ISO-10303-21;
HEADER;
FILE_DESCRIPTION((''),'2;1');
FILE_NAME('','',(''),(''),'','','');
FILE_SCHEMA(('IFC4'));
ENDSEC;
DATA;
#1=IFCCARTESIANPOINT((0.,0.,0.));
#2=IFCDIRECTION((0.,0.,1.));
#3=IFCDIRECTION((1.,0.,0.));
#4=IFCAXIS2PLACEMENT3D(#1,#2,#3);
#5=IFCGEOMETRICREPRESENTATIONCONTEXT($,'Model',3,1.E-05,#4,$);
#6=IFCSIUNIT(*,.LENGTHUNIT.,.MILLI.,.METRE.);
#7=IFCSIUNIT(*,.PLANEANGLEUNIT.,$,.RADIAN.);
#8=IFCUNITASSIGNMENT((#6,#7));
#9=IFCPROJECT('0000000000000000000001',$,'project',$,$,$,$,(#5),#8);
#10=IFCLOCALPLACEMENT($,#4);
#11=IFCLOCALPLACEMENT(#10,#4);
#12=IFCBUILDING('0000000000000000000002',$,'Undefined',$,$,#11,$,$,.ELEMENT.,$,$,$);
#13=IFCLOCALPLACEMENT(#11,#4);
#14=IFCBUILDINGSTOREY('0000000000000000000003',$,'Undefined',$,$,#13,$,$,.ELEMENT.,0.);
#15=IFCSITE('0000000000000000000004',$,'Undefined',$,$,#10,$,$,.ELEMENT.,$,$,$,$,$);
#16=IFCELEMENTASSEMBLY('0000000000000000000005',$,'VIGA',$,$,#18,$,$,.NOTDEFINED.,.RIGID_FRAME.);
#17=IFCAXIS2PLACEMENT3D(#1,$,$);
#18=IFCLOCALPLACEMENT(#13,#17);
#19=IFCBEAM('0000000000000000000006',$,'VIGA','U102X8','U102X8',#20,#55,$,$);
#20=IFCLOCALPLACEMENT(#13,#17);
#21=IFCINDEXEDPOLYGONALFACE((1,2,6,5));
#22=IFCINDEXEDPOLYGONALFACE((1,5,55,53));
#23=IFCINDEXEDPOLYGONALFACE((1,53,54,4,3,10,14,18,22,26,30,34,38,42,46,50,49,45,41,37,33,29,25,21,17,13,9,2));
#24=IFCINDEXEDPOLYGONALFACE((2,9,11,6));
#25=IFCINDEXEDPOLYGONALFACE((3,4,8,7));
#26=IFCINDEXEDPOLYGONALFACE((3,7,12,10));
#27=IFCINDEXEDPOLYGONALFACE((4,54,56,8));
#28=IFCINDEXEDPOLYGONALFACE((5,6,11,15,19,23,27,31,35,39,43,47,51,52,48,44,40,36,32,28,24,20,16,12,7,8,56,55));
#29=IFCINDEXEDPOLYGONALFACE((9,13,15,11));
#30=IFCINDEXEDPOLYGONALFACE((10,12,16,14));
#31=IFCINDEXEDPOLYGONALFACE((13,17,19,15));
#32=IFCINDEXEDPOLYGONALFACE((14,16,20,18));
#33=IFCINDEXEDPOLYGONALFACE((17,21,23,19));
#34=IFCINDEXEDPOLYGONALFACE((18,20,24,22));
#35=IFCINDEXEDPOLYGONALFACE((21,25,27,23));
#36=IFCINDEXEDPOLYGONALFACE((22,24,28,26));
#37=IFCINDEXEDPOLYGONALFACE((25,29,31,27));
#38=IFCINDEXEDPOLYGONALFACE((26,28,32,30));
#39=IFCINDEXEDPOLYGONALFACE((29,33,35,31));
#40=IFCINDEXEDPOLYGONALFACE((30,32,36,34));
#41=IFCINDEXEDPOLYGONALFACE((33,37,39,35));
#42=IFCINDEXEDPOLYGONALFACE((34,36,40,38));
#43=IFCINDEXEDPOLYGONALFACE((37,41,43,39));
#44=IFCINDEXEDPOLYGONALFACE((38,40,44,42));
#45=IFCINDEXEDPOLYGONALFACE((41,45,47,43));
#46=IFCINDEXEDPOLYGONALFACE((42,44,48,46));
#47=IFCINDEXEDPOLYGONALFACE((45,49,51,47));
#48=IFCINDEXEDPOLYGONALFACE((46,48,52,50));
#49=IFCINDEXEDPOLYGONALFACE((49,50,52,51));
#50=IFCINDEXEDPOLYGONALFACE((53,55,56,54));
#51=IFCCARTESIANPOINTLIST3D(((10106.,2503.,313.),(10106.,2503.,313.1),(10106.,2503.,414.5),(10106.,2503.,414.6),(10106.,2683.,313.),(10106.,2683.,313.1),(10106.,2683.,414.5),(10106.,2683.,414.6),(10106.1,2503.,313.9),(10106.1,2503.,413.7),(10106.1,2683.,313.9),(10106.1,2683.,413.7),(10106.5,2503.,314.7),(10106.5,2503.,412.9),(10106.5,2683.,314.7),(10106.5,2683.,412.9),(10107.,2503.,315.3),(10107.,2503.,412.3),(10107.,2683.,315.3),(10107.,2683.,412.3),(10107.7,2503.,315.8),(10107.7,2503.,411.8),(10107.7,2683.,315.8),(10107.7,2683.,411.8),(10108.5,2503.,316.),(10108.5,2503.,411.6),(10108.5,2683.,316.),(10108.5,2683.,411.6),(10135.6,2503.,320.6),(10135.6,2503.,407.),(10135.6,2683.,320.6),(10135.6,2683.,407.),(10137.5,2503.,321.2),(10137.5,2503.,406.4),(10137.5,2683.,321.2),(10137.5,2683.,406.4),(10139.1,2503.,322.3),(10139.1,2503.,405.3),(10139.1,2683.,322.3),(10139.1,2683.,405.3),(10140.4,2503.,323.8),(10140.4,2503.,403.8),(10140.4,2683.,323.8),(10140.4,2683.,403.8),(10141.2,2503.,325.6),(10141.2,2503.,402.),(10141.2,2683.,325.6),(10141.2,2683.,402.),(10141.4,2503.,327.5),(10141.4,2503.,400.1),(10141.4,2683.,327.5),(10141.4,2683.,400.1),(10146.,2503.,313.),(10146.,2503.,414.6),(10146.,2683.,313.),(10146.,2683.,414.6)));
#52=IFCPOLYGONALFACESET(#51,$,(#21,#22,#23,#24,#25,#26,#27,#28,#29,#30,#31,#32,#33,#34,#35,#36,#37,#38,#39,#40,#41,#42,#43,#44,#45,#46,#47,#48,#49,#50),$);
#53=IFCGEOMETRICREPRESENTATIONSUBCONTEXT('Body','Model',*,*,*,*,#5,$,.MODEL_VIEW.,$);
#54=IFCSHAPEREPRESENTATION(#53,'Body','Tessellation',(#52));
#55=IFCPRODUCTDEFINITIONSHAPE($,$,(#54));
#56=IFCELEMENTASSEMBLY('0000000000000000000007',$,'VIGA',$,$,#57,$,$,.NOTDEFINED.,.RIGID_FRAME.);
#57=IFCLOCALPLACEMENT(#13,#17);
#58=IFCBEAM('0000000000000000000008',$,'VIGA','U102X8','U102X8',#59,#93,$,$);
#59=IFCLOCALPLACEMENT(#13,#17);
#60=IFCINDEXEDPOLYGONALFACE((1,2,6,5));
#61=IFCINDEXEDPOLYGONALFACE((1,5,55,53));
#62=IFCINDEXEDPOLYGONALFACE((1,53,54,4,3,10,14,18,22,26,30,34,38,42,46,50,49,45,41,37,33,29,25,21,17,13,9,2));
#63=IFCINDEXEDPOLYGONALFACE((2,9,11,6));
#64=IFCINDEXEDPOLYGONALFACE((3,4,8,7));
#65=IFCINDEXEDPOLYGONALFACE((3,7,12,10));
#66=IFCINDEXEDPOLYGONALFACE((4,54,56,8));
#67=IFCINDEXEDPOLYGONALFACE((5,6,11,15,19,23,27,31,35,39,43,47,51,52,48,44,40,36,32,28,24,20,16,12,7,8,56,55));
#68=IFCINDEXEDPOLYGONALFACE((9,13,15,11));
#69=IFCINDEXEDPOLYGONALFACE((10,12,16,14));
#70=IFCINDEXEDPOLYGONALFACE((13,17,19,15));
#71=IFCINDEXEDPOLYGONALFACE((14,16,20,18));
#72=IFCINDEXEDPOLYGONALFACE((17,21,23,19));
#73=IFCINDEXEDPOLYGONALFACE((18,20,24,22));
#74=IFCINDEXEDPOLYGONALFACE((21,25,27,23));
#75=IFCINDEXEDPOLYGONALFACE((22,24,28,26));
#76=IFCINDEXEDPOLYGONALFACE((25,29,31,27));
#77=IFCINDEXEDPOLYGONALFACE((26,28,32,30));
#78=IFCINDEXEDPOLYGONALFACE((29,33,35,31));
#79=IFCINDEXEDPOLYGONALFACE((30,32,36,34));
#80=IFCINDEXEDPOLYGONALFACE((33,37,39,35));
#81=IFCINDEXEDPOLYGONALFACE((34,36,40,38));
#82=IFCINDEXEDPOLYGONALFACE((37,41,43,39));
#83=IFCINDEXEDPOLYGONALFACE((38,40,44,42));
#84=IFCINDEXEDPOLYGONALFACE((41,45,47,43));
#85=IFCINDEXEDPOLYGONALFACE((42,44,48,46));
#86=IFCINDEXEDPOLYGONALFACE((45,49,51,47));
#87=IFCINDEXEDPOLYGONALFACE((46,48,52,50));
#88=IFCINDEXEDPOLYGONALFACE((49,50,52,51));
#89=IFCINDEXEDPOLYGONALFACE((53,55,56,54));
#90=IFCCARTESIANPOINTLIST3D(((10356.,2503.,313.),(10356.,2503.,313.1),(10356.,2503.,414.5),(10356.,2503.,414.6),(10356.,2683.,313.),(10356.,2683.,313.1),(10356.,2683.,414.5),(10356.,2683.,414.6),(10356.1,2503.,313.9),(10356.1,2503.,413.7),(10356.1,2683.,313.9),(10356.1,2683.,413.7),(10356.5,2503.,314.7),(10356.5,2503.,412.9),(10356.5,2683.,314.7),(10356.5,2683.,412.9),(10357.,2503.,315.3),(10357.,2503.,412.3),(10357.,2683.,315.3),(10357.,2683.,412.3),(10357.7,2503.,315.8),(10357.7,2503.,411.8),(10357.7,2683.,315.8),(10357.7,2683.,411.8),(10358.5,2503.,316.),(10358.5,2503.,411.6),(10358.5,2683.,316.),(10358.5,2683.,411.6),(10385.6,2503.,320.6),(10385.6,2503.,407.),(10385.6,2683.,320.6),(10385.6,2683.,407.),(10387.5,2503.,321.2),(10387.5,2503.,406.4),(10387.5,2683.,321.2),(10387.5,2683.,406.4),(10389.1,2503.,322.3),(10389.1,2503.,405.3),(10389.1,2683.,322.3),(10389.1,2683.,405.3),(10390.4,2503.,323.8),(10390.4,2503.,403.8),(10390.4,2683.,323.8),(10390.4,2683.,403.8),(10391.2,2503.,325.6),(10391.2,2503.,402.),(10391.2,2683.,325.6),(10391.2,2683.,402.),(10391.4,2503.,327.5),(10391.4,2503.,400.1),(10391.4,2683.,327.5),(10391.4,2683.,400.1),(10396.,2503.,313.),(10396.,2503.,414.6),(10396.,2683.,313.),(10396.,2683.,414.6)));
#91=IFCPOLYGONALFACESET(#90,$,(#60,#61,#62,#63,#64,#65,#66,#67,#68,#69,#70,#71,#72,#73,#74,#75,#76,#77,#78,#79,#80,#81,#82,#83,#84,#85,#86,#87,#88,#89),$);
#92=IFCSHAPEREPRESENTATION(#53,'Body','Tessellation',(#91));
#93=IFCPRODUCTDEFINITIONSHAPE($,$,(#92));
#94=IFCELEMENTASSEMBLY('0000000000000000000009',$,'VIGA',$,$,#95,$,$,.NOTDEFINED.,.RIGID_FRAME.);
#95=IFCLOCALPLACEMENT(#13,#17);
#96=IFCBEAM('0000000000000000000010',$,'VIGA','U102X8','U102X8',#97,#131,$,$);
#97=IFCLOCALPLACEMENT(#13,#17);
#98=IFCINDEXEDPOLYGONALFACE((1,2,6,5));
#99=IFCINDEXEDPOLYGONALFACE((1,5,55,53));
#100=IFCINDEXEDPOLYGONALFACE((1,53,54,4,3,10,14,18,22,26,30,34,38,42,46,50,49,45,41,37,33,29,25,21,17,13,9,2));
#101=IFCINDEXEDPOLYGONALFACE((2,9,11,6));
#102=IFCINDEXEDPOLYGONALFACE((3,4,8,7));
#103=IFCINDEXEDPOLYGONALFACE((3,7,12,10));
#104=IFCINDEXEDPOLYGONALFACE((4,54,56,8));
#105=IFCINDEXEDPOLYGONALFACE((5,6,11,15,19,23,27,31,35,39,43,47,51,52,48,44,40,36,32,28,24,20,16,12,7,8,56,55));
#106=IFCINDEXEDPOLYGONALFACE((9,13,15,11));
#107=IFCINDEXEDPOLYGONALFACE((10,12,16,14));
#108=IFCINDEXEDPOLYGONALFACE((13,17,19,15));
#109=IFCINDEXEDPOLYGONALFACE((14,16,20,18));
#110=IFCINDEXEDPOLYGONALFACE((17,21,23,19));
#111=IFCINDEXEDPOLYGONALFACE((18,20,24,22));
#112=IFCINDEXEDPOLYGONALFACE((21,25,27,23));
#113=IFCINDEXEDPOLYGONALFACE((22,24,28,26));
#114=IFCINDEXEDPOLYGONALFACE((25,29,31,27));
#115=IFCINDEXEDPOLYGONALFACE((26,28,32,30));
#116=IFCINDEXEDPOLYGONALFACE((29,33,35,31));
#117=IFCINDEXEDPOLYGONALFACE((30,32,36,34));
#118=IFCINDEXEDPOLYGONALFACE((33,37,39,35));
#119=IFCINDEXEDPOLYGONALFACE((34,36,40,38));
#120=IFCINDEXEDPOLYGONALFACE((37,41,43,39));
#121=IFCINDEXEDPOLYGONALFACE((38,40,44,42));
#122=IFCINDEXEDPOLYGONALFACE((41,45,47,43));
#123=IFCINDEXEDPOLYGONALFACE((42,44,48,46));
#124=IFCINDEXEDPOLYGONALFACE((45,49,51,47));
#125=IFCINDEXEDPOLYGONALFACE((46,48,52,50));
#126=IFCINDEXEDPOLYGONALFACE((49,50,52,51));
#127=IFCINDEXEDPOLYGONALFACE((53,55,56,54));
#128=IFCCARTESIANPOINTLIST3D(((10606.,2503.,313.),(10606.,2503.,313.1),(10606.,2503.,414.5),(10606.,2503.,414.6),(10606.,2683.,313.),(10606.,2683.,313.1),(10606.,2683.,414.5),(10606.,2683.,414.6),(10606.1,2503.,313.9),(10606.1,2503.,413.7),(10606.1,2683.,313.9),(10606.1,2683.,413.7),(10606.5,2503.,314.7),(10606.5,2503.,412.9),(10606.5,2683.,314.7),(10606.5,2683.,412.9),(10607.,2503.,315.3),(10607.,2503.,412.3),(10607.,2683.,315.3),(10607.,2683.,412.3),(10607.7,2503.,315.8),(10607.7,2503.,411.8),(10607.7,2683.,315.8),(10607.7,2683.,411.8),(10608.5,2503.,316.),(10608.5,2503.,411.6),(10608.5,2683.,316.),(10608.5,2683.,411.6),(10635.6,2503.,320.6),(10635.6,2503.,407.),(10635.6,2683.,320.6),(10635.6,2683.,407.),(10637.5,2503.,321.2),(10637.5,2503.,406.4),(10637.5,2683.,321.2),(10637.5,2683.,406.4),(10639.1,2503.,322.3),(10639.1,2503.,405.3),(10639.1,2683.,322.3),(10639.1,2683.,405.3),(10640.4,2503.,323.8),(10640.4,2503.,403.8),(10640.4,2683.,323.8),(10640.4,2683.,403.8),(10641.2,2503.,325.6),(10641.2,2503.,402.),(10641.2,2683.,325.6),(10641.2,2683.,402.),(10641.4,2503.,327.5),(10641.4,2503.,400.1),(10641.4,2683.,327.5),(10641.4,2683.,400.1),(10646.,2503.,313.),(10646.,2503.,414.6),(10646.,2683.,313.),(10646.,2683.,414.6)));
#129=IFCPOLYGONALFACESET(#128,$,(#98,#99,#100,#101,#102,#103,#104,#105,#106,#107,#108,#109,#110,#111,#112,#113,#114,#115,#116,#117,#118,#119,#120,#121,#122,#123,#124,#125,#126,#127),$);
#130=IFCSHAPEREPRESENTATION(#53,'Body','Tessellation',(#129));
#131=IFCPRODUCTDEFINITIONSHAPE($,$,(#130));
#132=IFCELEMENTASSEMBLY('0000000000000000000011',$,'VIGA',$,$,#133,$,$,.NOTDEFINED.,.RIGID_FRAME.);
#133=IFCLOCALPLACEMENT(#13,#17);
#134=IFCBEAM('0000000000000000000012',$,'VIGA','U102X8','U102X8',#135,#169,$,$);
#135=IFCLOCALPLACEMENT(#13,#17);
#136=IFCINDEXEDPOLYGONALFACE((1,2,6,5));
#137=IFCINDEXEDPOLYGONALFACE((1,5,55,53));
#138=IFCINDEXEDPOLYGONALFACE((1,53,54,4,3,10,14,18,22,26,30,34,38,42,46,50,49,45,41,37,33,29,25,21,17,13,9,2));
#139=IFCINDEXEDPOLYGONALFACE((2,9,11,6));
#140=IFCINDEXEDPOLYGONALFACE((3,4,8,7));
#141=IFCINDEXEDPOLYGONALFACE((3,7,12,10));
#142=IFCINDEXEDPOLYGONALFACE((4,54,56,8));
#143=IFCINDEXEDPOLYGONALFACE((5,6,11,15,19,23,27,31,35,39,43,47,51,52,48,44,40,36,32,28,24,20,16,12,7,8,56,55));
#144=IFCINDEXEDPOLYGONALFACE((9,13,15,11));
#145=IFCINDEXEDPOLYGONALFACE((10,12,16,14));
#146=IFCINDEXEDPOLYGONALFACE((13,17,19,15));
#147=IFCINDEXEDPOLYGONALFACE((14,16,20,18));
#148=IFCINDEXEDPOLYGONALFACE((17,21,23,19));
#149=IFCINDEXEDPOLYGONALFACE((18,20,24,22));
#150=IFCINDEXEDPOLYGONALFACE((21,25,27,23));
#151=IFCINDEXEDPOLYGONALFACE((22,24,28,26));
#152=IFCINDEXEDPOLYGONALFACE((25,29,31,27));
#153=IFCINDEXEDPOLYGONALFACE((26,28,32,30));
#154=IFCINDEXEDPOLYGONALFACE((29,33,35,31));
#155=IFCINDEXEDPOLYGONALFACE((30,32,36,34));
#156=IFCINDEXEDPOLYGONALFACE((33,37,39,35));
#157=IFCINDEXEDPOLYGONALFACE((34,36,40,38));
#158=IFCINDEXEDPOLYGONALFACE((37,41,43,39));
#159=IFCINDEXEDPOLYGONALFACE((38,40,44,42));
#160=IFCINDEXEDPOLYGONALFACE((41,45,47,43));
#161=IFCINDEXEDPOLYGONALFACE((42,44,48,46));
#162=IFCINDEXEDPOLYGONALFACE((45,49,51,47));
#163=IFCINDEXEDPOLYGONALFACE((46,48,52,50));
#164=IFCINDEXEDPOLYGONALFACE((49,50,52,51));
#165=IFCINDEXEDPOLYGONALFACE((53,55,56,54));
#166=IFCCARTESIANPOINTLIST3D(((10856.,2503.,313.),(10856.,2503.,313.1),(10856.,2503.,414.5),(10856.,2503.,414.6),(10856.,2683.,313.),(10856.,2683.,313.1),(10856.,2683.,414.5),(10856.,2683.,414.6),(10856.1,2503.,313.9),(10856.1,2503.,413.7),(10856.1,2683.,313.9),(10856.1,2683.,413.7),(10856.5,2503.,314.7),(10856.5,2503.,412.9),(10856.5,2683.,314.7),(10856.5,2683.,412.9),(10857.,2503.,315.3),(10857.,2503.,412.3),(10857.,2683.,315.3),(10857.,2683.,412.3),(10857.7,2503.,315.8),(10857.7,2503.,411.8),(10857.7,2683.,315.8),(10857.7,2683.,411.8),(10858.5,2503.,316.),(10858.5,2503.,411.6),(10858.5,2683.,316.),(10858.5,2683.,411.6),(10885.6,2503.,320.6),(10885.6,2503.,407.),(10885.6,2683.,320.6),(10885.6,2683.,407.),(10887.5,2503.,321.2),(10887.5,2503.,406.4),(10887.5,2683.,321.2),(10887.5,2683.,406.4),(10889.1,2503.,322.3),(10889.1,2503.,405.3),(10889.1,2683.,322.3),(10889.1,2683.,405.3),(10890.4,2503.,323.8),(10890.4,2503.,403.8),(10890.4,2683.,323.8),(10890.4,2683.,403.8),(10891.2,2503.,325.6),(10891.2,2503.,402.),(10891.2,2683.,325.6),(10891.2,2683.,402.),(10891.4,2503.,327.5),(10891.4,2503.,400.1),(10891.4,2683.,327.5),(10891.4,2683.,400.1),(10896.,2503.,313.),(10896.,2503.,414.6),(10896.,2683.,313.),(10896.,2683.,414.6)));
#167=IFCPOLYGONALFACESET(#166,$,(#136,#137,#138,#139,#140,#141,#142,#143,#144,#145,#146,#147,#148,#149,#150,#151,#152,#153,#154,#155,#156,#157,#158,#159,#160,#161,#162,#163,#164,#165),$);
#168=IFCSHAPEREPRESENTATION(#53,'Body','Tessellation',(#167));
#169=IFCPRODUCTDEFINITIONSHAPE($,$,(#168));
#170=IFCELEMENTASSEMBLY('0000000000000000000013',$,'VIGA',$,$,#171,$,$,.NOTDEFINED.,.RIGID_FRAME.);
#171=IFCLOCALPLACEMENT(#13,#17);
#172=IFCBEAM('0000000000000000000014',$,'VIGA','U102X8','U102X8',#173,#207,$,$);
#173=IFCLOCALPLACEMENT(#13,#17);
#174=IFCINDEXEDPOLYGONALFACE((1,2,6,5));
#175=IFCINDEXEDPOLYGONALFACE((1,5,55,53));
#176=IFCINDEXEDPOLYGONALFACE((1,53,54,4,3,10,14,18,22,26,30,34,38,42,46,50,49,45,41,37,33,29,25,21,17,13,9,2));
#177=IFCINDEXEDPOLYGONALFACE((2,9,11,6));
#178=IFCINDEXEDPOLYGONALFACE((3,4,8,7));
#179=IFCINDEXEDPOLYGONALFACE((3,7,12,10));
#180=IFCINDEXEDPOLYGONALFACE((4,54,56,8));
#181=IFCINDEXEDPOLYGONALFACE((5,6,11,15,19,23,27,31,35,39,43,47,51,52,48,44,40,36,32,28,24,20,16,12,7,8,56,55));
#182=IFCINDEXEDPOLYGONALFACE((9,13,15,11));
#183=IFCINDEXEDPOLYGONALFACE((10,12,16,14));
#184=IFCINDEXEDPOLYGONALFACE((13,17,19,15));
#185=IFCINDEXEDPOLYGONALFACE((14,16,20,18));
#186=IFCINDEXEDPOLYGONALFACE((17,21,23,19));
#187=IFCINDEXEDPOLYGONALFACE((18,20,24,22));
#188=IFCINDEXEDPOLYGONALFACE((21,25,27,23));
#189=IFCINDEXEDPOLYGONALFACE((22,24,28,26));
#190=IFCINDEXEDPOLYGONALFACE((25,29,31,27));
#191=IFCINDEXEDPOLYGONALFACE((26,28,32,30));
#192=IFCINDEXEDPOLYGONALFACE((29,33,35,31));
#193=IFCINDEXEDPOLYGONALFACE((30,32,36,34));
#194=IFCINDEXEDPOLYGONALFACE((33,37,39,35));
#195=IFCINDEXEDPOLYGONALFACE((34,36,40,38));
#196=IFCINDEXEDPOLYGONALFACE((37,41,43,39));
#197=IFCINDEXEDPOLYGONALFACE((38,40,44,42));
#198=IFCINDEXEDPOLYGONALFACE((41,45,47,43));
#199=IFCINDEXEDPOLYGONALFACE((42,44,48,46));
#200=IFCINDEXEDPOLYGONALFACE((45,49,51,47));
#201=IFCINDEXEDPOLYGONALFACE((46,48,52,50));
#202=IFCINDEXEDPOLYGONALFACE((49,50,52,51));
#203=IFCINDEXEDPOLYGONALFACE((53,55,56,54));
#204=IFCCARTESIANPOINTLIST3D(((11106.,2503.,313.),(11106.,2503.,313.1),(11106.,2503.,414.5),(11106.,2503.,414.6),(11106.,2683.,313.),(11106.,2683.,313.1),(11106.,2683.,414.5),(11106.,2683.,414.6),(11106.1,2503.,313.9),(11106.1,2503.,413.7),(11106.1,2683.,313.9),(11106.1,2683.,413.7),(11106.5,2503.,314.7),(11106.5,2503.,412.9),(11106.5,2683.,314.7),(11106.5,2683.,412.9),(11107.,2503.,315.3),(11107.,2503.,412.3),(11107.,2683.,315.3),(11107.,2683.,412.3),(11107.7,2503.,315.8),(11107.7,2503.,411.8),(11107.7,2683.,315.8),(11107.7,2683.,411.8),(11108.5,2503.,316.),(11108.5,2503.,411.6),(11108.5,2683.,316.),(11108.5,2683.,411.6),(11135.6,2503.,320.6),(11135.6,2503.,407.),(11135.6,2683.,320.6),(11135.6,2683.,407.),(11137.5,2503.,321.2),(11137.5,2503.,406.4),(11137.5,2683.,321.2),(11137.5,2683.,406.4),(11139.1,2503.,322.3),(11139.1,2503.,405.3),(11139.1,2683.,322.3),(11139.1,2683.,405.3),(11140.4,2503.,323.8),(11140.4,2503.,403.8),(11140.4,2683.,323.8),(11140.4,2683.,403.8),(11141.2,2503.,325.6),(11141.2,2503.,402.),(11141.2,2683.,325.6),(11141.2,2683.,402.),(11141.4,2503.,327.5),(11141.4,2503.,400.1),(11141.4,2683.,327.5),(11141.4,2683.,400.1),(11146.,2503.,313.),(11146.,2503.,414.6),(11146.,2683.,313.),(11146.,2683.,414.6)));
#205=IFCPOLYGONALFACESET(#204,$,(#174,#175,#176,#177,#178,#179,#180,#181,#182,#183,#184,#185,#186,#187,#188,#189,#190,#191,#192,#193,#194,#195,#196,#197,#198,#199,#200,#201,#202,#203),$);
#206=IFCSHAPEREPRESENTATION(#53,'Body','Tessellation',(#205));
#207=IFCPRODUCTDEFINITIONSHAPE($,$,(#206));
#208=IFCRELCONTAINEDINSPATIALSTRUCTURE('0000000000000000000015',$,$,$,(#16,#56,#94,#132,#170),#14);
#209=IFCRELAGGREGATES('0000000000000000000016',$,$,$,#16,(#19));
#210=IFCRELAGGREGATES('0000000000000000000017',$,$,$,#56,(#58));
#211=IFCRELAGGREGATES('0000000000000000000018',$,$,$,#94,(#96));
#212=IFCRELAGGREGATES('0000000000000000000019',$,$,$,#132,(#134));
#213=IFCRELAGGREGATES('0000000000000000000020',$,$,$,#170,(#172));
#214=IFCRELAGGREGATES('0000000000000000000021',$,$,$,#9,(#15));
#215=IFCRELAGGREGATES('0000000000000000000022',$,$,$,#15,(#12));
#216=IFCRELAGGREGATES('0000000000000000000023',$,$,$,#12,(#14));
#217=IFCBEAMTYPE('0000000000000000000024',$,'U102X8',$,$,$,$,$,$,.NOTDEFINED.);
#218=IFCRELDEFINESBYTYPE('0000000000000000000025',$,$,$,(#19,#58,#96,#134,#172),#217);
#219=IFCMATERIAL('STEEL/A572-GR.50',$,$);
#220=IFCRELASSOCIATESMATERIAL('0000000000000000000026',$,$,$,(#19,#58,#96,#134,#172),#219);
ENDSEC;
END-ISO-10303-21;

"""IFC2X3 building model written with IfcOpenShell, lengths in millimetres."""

from ifc_helpers import new_model, si_unit, frame, origin_with_axes, origin_2d_with_axis, place, context, subcontext, project, spatial, u_section, extrude, material, type_object, element, aggregate, save


model = new_model("IFC2X3")

# Units and contexts
model_context = context("Model", 3, precision=1e-05, world=origin_with_axes())
body_context = subcontext(model_context, "Body", "Model", "MODEL_VIEW")
ifc_project = project(units=[si_unit("LENGTHUNIT", "METRE", prefix="MILLI"), si_unit("PLANEANGLEUNIT", "RADIAN")], contexts=[model_context])

# Site, building, storey
site_placement = place(None, origin_with_axes())
site = spatial("IfcSite", under=ifc_project, at=site_placement, Name="Undefined", CompositionType="ELEMENT")
building_placement = place(site_placement, origin_with_axes())
building = spatial("IfcBuilding", under=site, at=building_placement, Name="Undefined", CompositionType="ELEMENT")
storey_placement = place(building_placement, origin_with_axes())
storey = spatial("IfcBuildingStorey", under=building, at=storey_placement, Name="Undefined", CompositionType="ELEMENT", Elevation=0.0)

# Element assemblies, beams
ifc_material_1 = material(Name="STEEL/A572-GR.50")
beam_type = type_object("IfcBeamType", Name="U102X8", PredefinedType="NOTDEFINED")
assembly_1_placement = place(storey_placement, origin_with_axes())
assembly_1 = element("IfcElementAssembly", 1, at=assembly_1_placement, inside=storey, Name="VIGA", AssemblyPlace="NOTDEFINED", PredefinedType="RIGID_FRAME")
beam_1_placement = place(assembly_1_placement, frame((10126.0, 2683.0, 363.8), z_axis=(0.0, 0.0, 1.0), x_axis=(0.0, -1.0, 0.0)))
beam_1 = element("IfcBeam", 2, at=beam_1_placement, type_object=beam_type, material=ifc_material_1, Name="VIGA", Description="U102X8", ObjectType="U102X8", context=body_context, shape_type="SweptSolid", body=[
    extrude(u_section(Depth=101.6, FlangeWidth=40.0, WebThickness=4.6, FlangeThickness=6.0, FilletRadius=7.0, EdgeRadius=3.0, FlangeSlope=0.16839, at=origin_2d_with_axis()), frame((180.0, 0.0, 0.0), z_axis=(-1.0, 0.0, 0.0), x_axis=(0.0, -1.0, 0.0)), (0.0, 0.0, 1.0), 180.0),
])
aggregate(assembly_1, [beam_1])
assembly_2_placement = place(storey_placement, origin_with_axes())
assembly_2 = element("IfcElementAssembly", 3, at=assembly_2_placement, inside=storey, Name="VIGA", AssemblyPlace="NOTDEFINED", PredefinedType="RIGID_FRAME")
beam_2_placement = place(assembly_2_placement, frame((10376.0, 2683.0, 363.8), z_axis=(0.0, 0.0, 1.0), x_axis=(0.0, -1.0, 0.0)))
beam_2 = element("IfcBeam", 4, at=beam_2_placement, type_object=beam_type, material=ifc_material_1, Name="VIGA", Description="U102X8", ObjectType="U102X8", context=body_context, shape_type="SweptSolid", body=[
    extrude(u_section(Depth=101.6, FlangeWidth=40.0, WebThickness=4.6, FlangeThickness=6.0, FilletRadius=7.0, EdgeRadius=3.0, FlangeSlope=0.16839, at=origin_2d_with_axis()), frame((180.0, 0.0, 0.0), z_axis=(-1.0, 0.0, 0.0), x_axis=(0.0, -1.0, 0.0)), (0.0, 0.0, 1.0), 180.0),
])
aggregate(assembly_2, [beam_2])
assembly_3_placement = place(storey_placement, origin_with_axes())
assembly_3 = element("IfcElementAssembly", 5, at=assembly_3_placement, inside=storey, Name="VIGA", AssemblyPlace="NOTDEFINED", PredefinedType="RIGID_FRAME")
beam_3_placement = place(assembly_3_placement, frame((10626.0, 2683.0, 363.8), z_axis=(0.0, 0.0, 1.0), x_axis=(0.0, -1.0, 0.0)))
beam_3 = element("IfcBeam", 6, at=beam_3_placement, type_object=beam_type, material=ifc_material_1, Name="VIGA", Description="U102X8", ObjectType="U102X8", context=body_context, shape_type="SweptSolid", body=[
    extrude(u_section(Depth=101.6, FlangeWidth=40.0, WebThickness=4.6, FlangeThickness=6.0, FilletRadius=7.0, EdgeRadius=3.0, FlangeSlope=0.16839, at=origin_2d_with_axis()), frame((180.0, 0.0, 0.0), z_axis=(-1.0, 0.0, 0.0), x_axis=(0.0, -1.0, 0.0)), (0.0, 0.0, 1.0), 180.0),
])
aggregate(assembly_3, [beam_3])
assembly_4_placement = place(storey_placement, origin_with_axes())
assembly_4 = element("IfcElementAssembly", 7, at=assembly_4_placement, inside=storey, Name="VIGA", AssemblyPlace="NOTDEFINED", PredefinedType="RIGID_FRAME")
beam_4_placement = place(assembly_4_placement, frame((10876.0, 2683.0, 363.8), z_axis=(0.0, 0.0, 1.0), x_axis=(0.0, -1.0, 0.0)))
beam_4 = element("IfcBeam", 8, at=beam_4_placement, type_object=beam_type, material=ifc_material_1, Name="VIGA", Description="U102X8", ObjectType="U102X8", context=body_context, shape_type="SweptSolid", body=[
    extrude(u_section(Depth=101.6, FlangeWidth=40.0, WebThickness=4.6, FlangeThickness=6.0, FilletRadius=7.0, EdgeRadius=3.0, FlangeSlope=0.16839, at=origin_2d_with_axis()), frame((180.0, 0.0, 0.0), z_axis=(-1.0, 0.0, 0.0), x_axis=(0.0, -1.0, 0.0)), (0.0, 0.0, 1.0), 180.0),
])
aggregate(assembly_4, [beam_4])
assembly_5_placement = place(storey_placement, origin_with_axes())
assembly_5 = element("IfcElementAssembly", 9, at=assembly_5_placement, inside=storey, Name="VIGA", AssemblyPlace="NOTDEFINED", PredefinedType="RIGID_FRAME")
beam_5_placement = place(assembly_5_placement, frame((11126.0, 2683.0, 363.8), z_axis=(0.0, 0.0, 1.0), x_axis=(0.0, -1.0, 0.0)))
beam_5 = element("IfcBeam", 10, at=beam_5_placement, type_object=beam_type, material=ifc_material_1, Name="VIGA", Description="U102X8", ObjectType="U102X8", context=body_context, shape_type="SweptSolid", body=[
    extrude(u_section(Depth=101.6, FlangeWidth=40.0, WebThickness=4.6, FlangeThickness=6.0, FilletRadius=7.0, EdgeRadius=3.0, FlangeSlope=0.16839, at=origin_2d_with_axis()), frame((180.0, 0.0, 0.0), z_axis=(-1.0, 0.0, 0.0), x_axis=(0.0, -1.0, 0.0)), (0.0, 0.0, 1.0), 180.0),
])
aggregate(assembly_5, [beam_5])

save(model, "model.ifc")
